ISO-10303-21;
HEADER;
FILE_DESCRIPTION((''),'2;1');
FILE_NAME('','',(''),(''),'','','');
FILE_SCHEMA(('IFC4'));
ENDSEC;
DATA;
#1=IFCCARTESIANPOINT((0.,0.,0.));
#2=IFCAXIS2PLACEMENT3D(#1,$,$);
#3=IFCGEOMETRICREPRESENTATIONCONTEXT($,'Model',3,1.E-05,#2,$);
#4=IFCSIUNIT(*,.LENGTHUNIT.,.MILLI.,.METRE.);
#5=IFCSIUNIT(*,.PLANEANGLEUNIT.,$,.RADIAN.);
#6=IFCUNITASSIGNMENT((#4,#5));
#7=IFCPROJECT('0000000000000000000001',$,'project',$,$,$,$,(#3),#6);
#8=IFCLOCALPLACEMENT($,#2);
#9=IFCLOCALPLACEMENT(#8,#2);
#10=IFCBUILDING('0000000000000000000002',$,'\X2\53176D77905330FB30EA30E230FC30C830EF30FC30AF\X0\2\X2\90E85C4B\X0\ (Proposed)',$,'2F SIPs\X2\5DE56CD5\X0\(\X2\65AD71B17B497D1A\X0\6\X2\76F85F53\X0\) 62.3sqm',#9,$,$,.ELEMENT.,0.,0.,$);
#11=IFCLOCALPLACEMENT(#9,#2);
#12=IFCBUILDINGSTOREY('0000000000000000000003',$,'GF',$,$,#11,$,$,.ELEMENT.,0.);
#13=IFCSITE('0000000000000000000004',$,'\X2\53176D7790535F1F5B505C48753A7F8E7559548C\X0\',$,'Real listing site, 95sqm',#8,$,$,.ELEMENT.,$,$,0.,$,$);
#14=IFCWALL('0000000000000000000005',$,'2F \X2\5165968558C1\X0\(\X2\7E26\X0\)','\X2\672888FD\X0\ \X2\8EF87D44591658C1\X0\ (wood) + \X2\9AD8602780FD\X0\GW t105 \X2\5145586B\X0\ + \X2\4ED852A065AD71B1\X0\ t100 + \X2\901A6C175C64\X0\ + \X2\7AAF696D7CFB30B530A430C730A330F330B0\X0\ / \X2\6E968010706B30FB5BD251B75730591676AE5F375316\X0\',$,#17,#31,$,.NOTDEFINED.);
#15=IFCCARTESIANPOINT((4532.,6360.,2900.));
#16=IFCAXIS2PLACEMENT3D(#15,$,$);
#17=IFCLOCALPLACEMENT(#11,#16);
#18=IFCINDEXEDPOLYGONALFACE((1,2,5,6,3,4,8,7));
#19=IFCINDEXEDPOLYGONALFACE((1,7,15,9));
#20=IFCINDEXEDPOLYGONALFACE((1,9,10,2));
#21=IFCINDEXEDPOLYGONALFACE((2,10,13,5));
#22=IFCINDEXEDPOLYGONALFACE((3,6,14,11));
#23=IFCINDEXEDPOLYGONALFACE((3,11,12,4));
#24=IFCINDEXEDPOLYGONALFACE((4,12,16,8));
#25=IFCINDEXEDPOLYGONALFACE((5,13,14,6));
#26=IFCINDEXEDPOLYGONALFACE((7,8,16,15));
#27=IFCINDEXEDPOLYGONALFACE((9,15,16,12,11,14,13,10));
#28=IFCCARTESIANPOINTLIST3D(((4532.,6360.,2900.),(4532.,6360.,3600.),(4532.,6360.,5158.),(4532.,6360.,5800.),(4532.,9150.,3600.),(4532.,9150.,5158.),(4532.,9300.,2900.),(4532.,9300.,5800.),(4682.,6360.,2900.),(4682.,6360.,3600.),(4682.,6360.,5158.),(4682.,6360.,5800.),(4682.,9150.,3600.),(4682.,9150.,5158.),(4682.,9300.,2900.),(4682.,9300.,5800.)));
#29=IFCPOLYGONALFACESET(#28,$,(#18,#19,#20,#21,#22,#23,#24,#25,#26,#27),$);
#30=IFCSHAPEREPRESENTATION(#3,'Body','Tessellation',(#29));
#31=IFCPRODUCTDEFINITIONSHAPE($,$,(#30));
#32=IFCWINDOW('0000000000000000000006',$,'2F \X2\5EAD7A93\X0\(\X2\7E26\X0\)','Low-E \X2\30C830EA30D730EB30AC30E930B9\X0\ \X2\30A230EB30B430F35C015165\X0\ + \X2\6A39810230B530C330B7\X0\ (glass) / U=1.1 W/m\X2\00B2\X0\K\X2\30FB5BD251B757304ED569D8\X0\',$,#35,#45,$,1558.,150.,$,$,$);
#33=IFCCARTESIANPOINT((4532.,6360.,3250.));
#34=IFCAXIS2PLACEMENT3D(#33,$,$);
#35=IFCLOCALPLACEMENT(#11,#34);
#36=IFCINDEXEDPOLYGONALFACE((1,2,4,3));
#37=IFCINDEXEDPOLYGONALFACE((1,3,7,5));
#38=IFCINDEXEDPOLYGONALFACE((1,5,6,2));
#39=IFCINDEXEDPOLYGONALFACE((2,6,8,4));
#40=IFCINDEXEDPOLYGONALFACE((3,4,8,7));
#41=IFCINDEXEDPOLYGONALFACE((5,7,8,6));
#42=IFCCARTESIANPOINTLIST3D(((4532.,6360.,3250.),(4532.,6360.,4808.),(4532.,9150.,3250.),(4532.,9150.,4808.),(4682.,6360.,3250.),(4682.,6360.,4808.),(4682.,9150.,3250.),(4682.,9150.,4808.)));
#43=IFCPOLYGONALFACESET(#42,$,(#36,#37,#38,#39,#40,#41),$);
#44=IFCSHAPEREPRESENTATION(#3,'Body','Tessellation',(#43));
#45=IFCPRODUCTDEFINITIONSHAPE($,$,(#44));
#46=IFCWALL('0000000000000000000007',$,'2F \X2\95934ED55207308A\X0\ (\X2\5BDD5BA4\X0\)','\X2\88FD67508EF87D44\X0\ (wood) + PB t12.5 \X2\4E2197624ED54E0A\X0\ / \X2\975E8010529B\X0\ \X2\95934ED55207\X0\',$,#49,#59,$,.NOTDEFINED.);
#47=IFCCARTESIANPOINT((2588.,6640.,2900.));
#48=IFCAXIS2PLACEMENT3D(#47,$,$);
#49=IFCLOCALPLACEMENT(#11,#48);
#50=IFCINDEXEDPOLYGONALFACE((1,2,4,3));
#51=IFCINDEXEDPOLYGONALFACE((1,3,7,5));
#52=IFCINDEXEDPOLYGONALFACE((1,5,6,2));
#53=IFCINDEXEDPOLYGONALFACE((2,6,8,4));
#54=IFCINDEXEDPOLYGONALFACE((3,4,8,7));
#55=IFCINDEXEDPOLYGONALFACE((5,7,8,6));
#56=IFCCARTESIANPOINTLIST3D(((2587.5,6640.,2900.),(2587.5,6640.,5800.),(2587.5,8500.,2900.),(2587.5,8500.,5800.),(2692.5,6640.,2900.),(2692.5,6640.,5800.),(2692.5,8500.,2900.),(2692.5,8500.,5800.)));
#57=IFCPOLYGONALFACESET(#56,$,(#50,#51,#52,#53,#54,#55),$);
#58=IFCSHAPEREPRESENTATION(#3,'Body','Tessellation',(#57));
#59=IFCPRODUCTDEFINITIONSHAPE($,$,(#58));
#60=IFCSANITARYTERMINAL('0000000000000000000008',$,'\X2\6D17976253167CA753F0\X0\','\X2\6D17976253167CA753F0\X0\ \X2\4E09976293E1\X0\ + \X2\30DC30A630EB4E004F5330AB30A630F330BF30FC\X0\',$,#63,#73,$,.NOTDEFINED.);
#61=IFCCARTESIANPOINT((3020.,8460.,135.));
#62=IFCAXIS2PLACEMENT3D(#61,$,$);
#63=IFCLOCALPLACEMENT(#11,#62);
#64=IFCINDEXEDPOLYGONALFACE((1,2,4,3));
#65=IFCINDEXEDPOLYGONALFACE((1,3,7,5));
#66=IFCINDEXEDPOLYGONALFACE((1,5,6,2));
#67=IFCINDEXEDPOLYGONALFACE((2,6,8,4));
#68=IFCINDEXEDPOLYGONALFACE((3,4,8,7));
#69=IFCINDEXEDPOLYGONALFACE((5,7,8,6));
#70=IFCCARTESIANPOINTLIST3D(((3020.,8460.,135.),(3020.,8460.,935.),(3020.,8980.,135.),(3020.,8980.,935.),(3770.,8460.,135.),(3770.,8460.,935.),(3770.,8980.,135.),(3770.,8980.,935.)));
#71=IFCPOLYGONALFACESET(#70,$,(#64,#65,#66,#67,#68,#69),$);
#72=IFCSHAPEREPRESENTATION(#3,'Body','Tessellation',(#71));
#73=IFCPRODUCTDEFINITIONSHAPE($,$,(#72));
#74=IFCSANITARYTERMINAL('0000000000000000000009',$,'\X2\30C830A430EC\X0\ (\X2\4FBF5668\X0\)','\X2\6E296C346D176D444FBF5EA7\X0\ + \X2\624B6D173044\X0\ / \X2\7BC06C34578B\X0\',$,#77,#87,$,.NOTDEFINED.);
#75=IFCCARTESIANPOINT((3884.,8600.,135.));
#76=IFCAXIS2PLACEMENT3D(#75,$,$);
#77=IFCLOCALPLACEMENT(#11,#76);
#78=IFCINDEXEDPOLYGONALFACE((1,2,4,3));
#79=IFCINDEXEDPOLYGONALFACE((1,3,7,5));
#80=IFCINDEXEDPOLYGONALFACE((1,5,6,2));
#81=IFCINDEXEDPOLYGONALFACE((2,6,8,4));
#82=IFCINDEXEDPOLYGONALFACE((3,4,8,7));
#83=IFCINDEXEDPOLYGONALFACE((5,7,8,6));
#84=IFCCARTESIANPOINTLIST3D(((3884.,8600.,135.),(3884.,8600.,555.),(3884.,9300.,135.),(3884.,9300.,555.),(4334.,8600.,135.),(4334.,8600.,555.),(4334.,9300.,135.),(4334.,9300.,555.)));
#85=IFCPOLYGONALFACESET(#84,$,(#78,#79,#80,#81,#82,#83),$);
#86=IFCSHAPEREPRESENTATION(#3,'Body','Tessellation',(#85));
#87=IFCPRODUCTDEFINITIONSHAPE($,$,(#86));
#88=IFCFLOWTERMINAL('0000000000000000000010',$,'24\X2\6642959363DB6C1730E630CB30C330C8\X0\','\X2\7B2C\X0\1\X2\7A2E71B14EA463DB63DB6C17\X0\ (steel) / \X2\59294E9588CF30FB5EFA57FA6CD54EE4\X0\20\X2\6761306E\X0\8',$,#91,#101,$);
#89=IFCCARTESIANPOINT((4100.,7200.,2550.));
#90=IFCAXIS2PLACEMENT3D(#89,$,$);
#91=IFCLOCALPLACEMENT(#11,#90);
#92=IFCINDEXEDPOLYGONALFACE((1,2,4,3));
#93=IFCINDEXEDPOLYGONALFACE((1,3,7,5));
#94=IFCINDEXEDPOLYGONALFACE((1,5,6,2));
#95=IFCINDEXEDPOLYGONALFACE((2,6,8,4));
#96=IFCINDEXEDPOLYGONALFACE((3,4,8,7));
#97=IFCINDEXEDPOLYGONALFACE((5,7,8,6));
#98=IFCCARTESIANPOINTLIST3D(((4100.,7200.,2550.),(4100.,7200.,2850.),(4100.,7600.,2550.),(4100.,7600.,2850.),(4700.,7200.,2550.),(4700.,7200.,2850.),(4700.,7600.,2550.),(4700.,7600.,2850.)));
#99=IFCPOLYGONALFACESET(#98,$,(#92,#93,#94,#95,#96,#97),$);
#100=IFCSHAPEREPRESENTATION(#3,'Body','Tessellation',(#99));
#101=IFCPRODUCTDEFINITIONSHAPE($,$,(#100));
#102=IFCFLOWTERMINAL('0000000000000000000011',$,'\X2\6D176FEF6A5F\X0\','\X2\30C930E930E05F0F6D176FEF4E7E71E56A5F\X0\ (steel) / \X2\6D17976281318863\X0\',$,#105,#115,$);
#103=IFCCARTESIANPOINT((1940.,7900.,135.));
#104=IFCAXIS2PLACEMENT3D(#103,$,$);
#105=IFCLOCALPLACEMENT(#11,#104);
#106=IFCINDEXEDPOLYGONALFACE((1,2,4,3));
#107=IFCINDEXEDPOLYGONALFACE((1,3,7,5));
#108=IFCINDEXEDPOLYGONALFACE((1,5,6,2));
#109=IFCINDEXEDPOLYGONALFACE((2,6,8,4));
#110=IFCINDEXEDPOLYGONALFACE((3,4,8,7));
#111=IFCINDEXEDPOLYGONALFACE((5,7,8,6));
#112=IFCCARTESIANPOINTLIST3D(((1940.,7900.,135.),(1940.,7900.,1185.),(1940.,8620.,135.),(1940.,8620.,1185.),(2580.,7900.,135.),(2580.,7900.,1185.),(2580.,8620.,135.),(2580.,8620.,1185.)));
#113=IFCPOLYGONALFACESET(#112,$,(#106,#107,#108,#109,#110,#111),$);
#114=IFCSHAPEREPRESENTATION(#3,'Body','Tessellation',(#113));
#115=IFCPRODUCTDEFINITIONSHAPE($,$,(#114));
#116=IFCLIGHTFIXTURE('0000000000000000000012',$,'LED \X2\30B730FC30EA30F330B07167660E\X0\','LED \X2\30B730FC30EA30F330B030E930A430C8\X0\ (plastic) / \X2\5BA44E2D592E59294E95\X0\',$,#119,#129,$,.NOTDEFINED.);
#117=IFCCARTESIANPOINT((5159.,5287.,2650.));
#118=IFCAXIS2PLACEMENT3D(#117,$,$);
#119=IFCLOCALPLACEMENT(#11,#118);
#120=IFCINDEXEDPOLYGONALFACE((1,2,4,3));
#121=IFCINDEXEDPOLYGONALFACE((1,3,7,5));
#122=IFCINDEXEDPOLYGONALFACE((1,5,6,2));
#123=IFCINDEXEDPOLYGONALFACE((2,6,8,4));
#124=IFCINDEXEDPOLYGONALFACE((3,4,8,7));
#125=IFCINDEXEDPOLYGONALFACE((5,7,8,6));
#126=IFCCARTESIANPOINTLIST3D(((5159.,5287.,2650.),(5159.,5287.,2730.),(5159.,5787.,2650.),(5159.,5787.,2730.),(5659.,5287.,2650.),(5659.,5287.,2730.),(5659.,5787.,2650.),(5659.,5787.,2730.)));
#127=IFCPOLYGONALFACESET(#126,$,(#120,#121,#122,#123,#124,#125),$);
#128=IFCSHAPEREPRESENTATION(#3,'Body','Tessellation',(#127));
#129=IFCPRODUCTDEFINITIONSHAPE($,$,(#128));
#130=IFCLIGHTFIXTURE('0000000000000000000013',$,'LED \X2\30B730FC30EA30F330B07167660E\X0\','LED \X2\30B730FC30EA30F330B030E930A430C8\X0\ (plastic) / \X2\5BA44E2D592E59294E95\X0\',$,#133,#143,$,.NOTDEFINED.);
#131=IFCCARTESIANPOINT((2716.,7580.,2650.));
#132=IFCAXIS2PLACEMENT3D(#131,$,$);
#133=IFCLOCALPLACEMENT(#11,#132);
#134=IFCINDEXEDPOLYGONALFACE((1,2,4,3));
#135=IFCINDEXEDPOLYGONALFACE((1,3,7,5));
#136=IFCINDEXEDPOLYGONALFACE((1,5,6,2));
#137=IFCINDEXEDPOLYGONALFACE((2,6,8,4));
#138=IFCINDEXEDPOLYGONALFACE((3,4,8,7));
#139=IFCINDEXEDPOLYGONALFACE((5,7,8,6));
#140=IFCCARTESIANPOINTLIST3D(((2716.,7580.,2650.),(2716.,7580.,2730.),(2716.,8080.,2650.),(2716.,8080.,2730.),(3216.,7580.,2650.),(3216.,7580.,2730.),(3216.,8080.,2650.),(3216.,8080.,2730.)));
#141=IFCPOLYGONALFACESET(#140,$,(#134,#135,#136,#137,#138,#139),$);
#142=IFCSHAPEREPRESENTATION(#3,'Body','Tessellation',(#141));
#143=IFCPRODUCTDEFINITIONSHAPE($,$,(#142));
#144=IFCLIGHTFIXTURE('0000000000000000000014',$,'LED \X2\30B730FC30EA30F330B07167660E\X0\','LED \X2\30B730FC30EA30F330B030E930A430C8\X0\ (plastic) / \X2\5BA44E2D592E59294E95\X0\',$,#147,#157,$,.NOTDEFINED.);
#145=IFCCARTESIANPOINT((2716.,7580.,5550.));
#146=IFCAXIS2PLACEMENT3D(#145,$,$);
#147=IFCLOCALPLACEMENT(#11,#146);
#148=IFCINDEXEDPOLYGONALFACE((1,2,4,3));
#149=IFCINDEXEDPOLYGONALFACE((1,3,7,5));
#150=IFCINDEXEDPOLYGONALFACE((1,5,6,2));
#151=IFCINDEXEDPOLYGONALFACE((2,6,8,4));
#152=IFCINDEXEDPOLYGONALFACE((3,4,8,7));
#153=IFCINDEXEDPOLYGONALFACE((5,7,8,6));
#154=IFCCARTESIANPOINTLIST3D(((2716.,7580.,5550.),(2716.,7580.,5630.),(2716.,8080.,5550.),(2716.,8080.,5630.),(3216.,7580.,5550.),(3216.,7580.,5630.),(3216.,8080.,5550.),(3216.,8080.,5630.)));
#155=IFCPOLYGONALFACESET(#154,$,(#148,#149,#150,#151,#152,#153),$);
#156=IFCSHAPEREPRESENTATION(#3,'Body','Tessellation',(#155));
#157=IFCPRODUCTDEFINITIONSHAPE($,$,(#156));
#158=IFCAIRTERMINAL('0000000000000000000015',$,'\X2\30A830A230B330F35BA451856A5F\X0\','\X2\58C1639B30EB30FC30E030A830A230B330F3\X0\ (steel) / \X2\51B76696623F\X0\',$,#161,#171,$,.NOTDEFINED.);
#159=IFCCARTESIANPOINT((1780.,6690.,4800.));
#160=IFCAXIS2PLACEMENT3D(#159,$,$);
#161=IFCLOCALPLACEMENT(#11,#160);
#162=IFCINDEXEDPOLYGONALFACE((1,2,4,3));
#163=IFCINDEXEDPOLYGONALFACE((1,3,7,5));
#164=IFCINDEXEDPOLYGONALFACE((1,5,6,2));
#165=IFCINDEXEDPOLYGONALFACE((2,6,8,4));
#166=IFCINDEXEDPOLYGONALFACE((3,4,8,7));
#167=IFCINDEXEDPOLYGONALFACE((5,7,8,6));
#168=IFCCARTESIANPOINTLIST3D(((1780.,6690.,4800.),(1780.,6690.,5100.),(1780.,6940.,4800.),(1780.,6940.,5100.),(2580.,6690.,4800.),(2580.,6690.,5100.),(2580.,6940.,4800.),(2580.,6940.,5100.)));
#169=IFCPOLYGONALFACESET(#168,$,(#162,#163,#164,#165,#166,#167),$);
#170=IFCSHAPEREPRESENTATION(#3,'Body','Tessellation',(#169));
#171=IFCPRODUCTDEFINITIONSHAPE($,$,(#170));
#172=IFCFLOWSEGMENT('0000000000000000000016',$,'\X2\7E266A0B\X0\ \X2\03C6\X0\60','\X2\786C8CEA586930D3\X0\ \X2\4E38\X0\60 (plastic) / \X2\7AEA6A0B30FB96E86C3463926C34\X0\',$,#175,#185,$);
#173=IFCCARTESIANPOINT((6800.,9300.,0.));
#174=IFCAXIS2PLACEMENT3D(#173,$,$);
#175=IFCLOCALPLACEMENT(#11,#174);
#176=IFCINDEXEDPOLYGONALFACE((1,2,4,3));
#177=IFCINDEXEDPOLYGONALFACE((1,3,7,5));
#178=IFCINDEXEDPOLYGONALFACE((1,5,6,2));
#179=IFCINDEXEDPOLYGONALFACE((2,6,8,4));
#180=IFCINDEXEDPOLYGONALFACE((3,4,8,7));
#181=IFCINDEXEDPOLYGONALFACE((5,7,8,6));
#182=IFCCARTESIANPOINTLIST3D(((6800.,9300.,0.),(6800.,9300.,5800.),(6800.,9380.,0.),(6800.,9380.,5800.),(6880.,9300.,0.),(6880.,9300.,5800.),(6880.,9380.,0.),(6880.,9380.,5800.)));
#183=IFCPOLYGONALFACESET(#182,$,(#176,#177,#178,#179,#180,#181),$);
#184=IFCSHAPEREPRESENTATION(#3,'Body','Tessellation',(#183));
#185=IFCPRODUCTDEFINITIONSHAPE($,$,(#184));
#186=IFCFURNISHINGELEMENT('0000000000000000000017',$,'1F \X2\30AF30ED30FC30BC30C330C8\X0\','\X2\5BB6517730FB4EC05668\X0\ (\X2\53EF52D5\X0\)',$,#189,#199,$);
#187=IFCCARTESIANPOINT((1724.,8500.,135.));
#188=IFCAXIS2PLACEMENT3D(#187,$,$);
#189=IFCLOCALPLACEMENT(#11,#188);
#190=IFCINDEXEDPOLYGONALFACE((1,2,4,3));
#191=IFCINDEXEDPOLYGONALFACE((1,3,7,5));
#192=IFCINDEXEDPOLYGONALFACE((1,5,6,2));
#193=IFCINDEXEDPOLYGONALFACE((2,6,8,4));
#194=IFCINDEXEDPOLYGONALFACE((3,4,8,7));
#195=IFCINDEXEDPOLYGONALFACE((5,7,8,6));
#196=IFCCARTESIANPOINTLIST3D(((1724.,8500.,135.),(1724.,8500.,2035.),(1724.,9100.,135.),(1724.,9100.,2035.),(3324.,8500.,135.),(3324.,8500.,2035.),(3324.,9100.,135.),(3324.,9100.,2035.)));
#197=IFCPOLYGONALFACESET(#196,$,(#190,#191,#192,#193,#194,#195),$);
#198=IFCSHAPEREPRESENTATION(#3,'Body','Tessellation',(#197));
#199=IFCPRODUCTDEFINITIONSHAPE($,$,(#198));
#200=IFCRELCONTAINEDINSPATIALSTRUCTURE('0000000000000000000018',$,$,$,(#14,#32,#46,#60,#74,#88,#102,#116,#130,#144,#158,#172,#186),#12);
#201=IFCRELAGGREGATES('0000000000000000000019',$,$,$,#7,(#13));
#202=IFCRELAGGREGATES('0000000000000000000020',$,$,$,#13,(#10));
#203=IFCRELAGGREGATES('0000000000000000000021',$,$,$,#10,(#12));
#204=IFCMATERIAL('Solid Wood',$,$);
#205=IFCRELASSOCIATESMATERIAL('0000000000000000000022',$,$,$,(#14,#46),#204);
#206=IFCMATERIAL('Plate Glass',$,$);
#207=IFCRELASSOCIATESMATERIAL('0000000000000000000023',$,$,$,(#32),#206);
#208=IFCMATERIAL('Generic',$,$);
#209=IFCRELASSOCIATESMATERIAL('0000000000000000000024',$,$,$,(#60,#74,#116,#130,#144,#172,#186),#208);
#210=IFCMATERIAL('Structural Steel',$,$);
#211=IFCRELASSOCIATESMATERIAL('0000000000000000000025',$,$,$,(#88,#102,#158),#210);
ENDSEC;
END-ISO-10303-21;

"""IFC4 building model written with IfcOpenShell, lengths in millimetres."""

from ifc_helpers import new_model, si_unit, frame, frame_2d, origin, place, context, project, spatial, rectangle, extrude, material, element, fill, save


model = new_model("IFC4")

# Units and contexts
model_context = context("Model", 3, precision=1e-05, world=origin())
ifc_project = project(units=[si_unit("LENGTHUNIT", "METRE", prefix="MILLI"), si_unit("PLANEANGLEUNIT", "RADIAN")], contexts=[model_context])

# Site, building, storey
site_placement = place(None, origin())
site = spatial("IfcSite", under=ifc_project, at=site_placement, Name="北海道弟子屈町美留和", ObjectType="Real listing site, 95sqm", CompositionType="ELEMENT", RefElevation=0.0)
building_placement = place(site_placement, origin())
building = spatial("IfcBuilding", under=site, at=building_placement, Name="北海道・リモートワーク2部屋 (Proposed)", ObjectType="2F SIPs工法(断熱等級6相当) 62.3sqm", CompositionType="ELEMENT", ElevationOfRefHeight=0.0, ElevationOfTerrain=0.0)
storey_placement = place(building_placement, origin())
storey = spatial("IfcBuildingStorey", under=building, at=storey_placement, Name="GF", CompositionType="ELEMENT", Elevation=0.0)

# Shared definitions
ifc_material_1 = material(Name="Solid Wood")

# Shared definitions
ifc_material_2 = material(Name="Plate Glass")

# Wall, opening, window
wall_1_placement = place(storey_placement, frame((4532.0, 6360.0, 2900.0)))
wall_1 = element("IfcWall", 1, at=wall_1_placement, inside=storey, material=ifc_material_1, Name="2F 入隅壁(縦)", Description="木製 軸組外壁 (wood) + 高性能GW t105 充填 + 付加断熱 t100 + 通気層 + 窯業系サイディング / 準耐火・寒冷地外皮強化", PredefinedType="NOTDEFINED", context=model_context, shape_type="SweptSolid", body=[
    extrude(rectangle(XDim=150.0, YDim=2940.0, at=frame_2d((75.0, 1470.0))), frame((4532.0, 6360.0, 2900.0)), (0.0, 0.0, 1.0), 2900.0),
])
opening_1_placement = place(storey_placement, frame((4532.0, 6360.0, 3250.0)))
opening_1 = element("IfcOpeningElement", 2, at=opening_1_placement, cuts=wall_1, PredefinedType="NOTDEFINED", context=model_context, shape_type="SweptSolid", body=[
    extrude(rectangle(XDim=150.0, YDim=2790.0, at=frame_2d((75.0, 1395.0))), frame((4532.0, 6360.0, 3250.0)), (0.0, 0.0, 1.0), 1558.0),
])
window_1_placement = place(storey_placement, frame((4532.0, 6360.0, 3250.0)))
window_1 = element("IfcWindow", 3, at=window_1_placement, inside=storey, material=ifc_material_2, Name="2F 庭窓(縦)", Description="Low-E トリプルガラス アルゴン封入 + 樹脂サッシ (glass) / U=1.1 W/m²K・寒冷地仕様", OverallHeight=1558.0, OverallWidth=150.0, context=model_context, shape_type="SweptSolid", body=[
    extrude(rectangle(XDim=150.0, YDim=2790.0, at=frame_2d((75.0, 1395.0))), frame((4532.0, 6360.0, 3250.0)), (0.0, 0.0, 1.0), 1558.0),
])
fill(opening_1, window_1)

# Wall
wall_2_placement = place(storey_placement, frame((2588.0, 6640.0, 2900.0)))
element("IfcWall", 4, at=wall_2_placement, inside=storey, material=ifc_material_1, Name="2F 間仕切り (寝室)", Description="製材軸組 (wood) + PB t12.5 両面仕上 / 非耐力 間仕切", PredefinedType="NOTDEFINED", context=model_context, shape_type="SweptSolid", body=[
    extrude(rectangle(XDim=105.0, YDim=1860.0, at=frame_2d((52.0, 930.0))), frame((2588.0, 6640.0, 2900.0)), (0.0, 0.0, 1.0), 2900.0),
])

# Sanitary terminals
ifc_material_3 = material(Name="Generic")
sanitary_terminal_1_placement = place(storey_placement, frame((3020.0, 8460.0, 135.0)))
element("IfcSanitaryTerminal", 5, at=sanitary_terminal_1_placement, inside=storey, material=ifc_material_3, Name="洗面化粧台", Description="洗面化粧台 三面鏡 + ボウル一体カウンター", PredefinedType="NOTDEFINED", context=model_context, shape_type="SweptSolid", body=[
    extrude(rectangle(XDim=750.0, YDim=520.0, at=frame_2d((375.0, 260.0))), frame((3020.0, 8460.0, 135.0)), (0.0, 0.0, 1.0), 800.0),
])
sanitary_terminal_2_placement = place(storey_placement, frame((3884.0, 8600.0, 135.0)))
element("IfcSanitaryTerminal", 6, at=sanitary_terminal_2_placement, inside=storey, material=ifc_material_3, Name="トイレ (便器)", Description="温水洗浄便座 + 手洗い / 節水型", PredefinedType="NOTDEFINED", context=model_context, shape_type="SweptSolid", body=[
    extrude(rectangle(XDim=450.0, YDim=700.0, at=frame_2d((225.0, 350.0))), frame((3884.0, 8600.0, 135.0)), (0.0, 0.0, 1.0), 420.0),
])

# Flow terminals
ifc_material_4 = material(Name="Structural Steel")
flow_terminal_1_placement = place(storey_placement, frame((4100.0, 7200.0, 2550.0)))
element("IfcFlowTerminal", 7, at=flow_terminal_1_placement, inside=storey, material=ifc_material_4, Name="24時間換気ユニット", Description="第1種熱交換換気 (steel) / 天井裏・建基法令20条の8", context=model_context, shape_type="SweptSolid", body=[
    extrude(rectangle(XDim=600.0, YDim=400.0, at=frame_2d((300.0, 200.0))), frame((4100.0, 7200.0, 2550.0)), (0.0, 0.0, 1.0), 300.0),
])
flow_terminal_2_placement = place(storey_placement, frame((1940.0, 7900.0, 135.0)))
element("IfcFlowTerminal", 8, at=flow_terminal_2_placement, inside=storey, material=ifc_material_4, Name="洗濯機", Description="ドラム式洗濯乾燥機 (steel) / 洗面脱衣", context=model_context, shape_type="SweptSolid", body=[
    extrude(rectangle(XDim=640.0, YDim=720.0, at=frame_2d((320.0, 360.0))), frame((1940.0, 7900.0, 135.0)), (0.0, 0.0, 1.0), 1050.0),
])

# Light fixtures
light_fixture_1_placement = place(storey_placement, frame((5159.0, 5287.0, 2650.0)))
element("IfcLightFixture", 9, at=light_fixture_1_placement, inside=storey, material=ifc_material_3, Name="LED シーリング照明", Description="LED シーリングライト (plastic) / 室中央天井", PredefinedType="NOTDEFINED", context=model_context, shape_type="SweptSolid", body=[
    extrude(rectangle(XDim=500.0, YDim=500.0, at=frame_2d((250.0, 250.0))), frame((5159.0, 5287.0, 2650.0)), (0.0, 0.0, 1.0), 80.0),
])
light_fixture_2_placement = place(storey_placement, frame((2716.0, 7580.0, 2650.0)))
element("IfcLightFixture", 10, at=light_fixture_2_placement, inside=storey, material=ifc_material_3, Name="LED シーリング照明", Description="LED シーリングライト (plastic) / 室中央天井", PredefinedType="NOTDEFINED", context=model_context, shape_type="SweptSolid", body=[
    extrude(rectangle(XDim=500.0, YDim=500.0, at=frame_2d((250.0, 250.0))), frame((2716.0, 7580.0, 2650.0)), (0.0, 0.0, 1.0), 80.0),
])
light_fixture_3_placement = place(storey_placement, frame((2716.0, 7580.0, 5550.0)))
element("IfcLightFixture", 11, at=light_fixture_3_placement, inside=storey, material=ifc_material_3, Name="LED シーリング照明", Description="LED シーリングライト (plastic) / 室中央天井", PredefinedType="NOTDEFINED", context=model_context, shape_type="SweptSolid", body=[
    extrude(rectangle(XDim=500.0, YDim=500.0, at=frame_2d((250.0, 250.0))), frame((2716.0, 7580.0, 5550.0)), (0.0, 0.0, 1.0), 80.0),
])

# Air terminal
air_terminal_placement = place(storey_placement, frame((1780.0, 6690.0, 4800.0)))
element("IfcAirTerminal", 12, at=air_terminal_placement, inside=storey, material=ifc_material_4, Name="エアコン室内機", Description="壁掛ルームエアコン (steel) / 冷暖房", PredefinedType="NOTDEFINED", context=model_context, shape_type="SweptSolid", body=[
    extrude(rectangle(XDim=800.0, YDim=250.0, at=frame_2d((400.0, 125.0))), frame((1780.0, 6690.0, 4800.0)), (0.0, 0.0, 1.0), 300.0),
])

# Flow segment
flow_segment_placement = place(storey_placement, frame((6800.0, 9300.0, 0.0)))
element("IfcFlowSegment", 13, at=flow_segment_placement, inside=storey, material=ifc_material_3, Name="縦樋 φ60", Description="硬質塩ビ 丸60 (plastic) / 竪樋・雨水排水", context=model_context, shape_type="SweptSolid", body=[
    extrude(rectangle(XDim=80.0, YDim=80.0, at=frame_2d((40.0, 40.0))), frame((6800.0, 9300.0, 0.0)), (0.0, 0.0, 1.0), 5800.0),
])

# Furnishing element
furnishing_1_placement = place(storey_placement, frame((1724.0, 8500.0, 135.0)))
element("IfcFurnishingElement", 14, at=furnishing_1_placement, inside=storey, material=ifc_material_3, Name="1F クローゼット", Description="家具・什器 (可動)", context=model_context, shape_type="SweptSolid", body=[
    extrude(rectangle(XDim=1600.0, YDim=600.0, at=frame_2d((800.0, 300.0))), frame((1724.0, 8500.0, 135.0)), (0.0, 0.0, 1.0), 1900.0),
])

save(model, "model.ifc")
